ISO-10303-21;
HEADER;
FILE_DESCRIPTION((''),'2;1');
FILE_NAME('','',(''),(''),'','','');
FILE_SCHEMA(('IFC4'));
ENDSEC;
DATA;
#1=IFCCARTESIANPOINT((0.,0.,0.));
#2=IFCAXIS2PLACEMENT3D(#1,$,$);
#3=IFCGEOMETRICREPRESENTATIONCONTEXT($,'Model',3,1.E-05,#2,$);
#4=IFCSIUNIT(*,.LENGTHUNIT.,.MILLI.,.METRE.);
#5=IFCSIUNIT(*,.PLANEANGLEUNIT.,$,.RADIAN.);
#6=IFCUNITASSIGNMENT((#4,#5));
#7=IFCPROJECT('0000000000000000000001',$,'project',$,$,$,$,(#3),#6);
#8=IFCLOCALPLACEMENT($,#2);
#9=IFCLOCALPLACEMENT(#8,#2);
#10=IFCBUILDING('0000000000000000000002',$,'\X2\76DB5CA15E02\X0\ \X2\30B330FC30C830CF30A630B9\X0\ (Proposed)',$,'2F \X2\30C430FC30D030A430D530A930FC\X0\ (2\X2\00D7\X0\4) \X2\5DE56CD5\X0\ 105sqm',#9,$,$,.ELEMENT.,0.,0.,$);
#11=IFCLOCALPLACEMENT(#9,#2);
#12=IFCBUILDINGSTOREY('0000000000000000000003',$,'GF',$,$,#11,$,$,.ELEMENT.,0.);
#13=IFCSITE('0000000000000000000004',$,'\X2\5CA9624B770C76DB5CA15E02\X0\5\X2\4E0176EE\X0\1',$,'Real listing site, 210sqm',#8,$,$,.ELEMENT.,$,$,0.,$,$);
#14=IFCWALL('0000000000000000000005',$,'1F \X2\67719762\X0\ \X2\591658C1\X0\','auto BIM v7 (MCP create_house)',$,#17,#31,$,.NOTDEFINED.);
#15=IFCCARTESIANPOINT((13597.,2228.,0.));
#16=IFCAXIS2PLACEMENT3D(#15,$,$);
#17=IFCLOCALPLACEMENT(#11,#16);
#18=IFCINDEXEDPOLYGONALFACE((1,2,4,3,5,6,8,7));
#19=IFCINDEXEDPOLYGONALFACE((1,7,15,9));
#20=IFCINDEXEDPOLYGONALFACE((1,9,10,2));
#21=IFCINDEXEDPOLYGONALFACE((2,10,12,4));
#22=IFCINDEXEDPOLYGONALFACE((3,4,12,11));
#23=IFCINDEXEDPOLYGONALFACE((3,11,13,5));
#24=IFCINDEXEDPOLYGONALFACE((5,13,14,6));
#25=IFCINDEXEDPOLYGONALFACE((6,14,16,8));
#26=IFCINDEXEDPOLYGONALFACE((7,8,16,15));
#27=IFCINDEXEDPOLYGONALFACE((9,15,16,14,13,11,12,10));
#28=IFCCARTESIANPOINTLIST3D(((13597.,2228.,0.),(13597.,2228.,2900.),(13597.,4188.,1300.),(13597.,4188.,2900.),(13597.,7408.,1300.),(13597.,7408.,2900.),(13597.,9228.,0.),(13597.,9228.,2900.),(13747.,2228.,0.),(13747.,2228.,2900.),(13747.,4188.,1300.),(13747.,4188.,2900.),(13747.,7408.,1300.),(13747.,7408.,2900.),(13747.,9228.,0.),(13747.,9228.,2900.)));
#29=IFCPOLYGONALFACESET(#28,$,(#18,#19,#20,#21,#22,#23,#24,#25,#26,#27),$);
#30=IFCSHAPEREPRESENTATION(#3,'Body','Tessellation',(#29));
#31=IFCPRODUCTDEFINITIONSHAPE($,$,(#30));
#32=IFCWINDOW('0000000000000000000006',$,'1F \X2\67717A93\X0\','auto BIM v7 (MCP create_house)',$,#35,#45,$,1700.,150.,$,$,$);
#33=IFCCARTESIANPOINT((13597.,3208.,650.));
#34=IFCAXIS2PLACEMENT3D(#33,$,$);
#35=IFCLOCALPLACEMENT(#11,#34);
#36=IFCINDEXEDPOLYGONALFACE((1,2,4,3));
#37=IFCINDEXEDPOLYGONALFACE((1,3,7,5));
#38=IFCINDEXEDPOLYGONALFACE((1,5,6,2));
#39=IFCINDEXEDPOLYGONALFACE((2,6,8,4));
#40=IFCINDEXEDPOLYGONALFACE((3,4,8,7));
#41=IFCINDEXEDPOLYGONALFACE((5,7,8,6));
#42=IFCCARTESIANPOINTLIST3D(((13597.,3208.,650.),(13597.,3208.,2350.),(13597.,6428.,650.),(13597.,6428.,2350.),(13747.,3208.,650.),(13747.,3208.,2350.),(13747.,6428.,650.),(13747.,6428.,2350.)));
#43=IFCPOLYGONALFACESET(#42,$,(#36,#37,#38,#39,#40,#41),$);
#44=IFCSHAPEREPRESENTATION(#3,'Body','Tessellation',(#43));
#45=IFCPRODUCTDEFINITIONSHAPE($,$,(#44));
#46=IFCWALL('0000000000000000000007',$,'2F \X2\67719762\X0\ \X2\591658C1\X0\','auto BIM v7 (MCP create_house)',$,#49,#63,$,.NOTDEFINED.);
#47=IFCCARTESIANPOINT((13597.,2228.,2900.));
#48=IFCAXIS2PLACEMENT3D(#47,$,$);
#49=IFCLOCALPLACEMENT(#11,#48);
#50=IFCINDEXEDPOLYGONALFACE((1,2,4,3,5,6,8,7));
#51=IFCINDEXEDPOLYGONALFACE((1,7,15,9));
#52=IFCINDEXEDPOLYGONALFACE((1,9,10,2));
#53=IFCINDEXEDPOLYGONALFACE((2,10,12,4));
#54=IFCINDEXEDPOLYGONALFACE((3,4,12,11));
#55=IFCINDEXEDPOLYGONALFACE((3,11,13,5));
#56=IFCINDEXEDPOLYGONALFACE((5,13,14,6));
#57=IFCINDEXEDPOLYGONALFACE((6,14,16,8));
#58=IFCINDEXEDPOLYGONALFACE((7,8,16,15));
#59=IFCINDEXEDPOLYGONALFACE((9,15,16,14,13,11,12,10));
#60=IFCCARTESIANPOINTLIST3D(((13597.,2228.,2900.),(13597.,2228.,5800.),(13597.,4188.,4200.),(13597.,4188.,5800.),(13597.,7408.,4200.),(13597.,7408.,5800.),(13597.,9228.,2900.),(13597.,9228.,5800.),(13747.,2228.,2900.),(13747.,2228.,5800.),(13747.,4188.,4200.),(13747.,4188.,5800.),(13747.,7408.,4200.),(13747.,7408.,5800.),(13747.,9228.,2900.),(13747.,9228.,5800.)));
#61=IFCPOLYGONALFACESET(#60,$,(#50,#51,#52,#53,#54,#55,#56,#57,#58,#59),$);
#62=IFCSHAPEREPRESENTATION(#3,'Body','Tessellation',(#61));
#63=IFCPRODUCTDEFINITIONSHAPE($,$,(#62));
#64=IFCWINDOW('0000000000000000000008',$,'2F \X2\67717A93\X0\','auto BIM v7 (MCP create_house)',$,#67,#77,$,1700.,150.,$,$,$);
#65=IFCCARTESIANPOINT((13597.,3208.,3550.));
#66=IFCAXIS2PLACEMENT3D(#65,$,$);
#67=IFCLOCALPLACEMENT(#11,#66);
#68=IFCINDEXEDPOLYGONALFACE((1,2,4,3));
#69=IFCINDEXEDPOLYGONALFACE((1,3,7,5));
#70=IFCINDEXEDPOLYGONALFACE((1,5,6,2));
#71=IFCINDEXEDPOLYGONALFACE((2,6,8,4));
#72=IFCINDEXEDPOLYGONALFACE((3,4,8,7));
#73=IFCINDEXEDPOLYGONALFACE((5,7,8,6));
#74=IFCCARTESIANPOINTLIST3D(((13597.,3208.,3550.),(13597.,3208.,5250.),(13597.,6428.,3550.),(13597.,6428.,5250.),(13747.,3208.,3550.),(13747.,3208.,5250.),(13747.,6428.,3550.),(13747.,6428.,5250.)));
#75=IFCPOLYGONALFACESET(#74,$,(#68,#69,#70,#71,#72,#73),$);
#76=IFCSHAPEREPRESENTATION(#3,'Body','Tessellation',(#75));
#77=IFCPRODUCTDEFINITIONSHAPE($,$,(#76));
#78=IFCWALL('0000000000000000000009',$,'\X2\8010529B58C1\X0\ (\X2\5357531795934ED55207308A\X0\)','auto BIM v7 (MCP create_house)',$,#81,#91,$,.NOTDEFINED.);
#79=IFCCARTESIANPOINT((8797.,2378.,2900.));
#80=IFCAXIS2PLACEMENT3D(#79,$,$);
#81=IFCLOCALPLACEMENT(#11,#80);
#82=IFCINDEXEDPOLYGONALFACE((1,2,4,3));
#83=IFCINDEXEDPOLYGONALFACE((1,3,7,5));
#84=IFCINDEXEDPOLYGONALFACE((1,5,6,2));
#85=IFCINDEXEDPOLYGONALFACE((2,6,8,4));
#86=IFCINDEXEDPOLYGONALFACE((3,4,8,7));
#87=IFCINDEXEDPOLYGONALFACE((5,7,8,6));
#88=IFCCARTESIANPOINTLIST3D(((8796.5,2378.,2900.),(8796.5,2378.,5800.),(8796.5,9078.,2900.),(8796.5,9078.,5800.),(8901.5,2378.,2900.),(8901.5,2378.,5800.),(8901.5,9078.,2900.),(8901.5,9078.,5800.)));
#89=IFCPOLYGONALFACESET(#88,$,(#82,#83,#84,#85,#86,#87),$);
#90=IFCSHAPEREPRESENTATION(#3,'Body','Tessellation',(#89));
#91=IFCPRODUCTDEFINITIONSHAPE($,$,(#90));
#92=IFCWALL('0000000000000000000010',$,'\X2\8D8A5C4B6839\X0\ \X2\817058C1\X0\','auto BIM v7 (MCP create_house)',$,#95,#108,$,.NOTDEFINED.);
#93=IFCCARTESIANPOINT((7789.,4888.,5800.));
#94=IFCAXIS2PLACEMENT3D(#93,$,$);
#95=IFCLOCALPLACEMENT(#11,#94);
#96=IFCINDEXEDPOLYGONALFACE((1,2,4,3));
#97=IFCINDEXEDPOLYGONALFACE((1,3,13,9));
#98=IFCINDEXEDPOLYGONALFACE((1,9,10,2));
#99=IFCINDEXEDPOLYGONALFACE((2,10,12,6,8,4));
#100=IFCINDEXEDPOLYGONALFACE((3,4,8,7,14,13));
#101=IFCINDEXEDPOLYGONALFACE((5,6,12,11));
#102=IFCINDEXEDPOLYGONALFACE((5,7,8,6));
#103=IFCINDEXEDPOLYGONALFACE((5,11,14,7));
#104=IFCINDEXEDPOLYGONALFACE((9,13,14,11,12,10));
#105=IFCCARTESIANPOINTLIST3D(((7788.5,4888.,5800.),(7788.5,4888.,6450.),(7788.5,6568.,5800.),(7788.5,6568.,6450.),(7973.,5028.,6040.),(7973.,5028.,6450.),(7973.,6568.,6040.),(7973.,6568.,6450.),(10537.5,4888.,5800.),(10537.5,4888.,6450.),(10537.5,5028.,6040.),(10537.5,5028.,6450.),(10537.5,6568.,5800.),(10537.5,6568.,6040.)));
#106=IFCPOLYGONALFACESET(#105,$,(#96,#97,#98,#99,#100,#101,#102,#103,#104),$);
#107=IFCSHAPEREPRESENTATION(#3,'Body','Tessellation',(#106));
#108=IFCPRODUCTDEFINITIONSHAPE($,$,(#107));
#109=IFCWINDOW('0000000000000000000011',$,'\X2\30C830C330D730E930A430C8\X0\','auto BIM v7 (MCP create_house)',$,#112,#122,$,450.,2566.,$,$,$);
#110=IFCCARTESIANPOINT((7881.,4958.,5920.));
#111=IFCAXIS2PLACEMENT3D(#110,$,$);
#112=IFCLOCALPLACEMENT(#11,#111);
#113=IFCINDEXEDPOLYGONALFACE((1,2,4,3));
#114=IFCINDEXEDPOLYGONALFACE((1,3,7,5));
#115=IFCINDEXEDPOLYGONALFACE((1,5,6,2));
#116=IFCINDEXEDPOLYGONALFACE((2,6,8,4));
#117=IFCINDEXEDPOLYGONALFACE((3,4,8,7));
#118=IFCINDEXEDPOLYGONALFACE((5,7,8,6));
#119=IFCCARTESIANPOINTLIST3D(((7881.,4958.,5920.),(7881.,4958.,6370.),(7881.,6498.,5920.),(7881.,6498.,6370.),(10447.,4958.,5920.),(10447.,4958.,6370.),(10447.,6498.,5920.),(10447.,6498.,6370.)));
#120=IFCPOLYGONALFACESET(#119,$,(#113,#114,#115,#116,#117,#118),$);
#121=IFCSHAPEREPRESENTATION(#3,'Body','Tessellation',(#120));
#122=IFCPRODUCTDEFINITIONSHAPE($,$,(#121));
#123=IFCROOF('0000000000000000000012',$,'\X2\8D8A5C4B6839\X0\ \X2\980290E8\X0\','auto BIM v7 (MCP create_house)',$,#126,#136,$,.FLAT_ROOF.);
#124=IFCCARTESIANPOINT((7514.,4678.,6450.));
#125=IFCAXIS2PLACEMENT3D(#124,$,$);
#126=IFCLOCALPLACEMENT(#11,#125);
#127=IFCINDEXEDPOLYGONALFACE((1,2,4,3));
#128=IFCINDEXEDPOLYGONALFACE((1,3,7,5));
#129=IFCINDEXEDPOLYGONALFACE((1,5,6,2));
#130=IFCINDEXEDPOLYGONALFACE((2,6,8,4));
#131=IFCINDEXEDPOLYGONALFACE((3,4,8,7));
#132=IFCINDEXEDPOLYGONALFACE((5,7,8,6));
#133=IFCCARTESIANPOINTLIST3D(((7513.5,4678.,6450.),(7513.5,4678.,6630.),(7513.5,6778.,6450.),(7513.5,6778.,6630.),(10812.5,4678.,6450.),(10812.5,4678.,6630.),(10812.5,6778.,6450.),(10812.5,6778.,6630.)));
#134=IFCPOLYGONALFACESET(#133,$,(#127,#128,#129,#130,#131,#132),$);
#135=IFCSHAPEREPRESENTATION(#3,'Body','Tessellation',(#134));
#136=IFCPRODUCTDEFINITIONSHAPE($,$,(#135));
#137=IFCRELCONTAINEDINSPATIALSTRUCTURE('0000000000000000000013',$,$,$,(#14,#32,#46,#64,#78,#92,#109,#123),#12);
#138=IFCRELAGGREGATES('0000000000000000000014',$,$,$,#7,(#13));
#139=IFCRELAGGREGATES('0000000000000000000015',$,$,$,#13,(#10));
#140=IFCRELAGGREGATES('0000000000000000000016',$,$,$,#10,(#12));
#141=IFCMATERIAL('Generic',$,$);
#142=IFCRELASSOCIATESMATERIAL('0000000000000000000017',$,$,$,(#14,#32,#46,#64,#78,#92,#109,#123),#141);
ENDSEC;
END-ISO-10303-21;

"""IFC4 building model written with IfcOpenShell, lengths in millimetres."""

from ifc_helpers import new_model, si_unit, frame, frame_2d, origin, place, context, project, spatial, rectangle, extrude, material, element, fill, save


model = new_model("IFC4")

# Units and contexts
model_context = context("Model", 3, precision=1e-05, world=origin())
ifc_project = project(units=[si_unit("LENGTHUNIT", "METRE", prefix="MILLI"), si_unit("PLANEANGLEUNIT", "RADIAN")], contexts=[model_context])

# Site, building, storey
site_placement = place(None, origin())
site = spatial("IfcSite", under=ifc_project, at=site_placement, Name="岩手県盛岡市5丁目1", ObjectType="Real listing site, 210sqm", CompositionType="ELEMENT", RefElevation=0.0)
building_placement = place(site_placement, origin())
building = spatial("IfcBuilding", under=site, at=building_placement, Name="盛岡市 コートハウス (Proposed)", ObjectType="2F ツーバイフォー (2×4) 工法 105sqm", CompositionType="ELEMENT", ElevationOfRefHeight=0.0, ElevationOfTerrain=0.0)
storey_placement = place(building_placement, origin())
storey = spatial("IfcBuildingStorey", under=building, at=storey_placement, Name="GF", CompositionType="ELEMENT", Elevation=0.0)

# Shared definitions
ifc_material = material(Name="Generic")

# Wall, opening, window
wall_1_placement = place(storey_placement, frame((13597.0, 2228.0, 0.0)))
wall_1 = element("IfcWall", 1, at=wall_1_placement, inside=storey, material=ifc_material, Name="1F 東面 外壁", Description="auto BIM v7 (MCP create_house)", PredefinedType="NOTDEFINED", context=model_context, shape_type="SweptSolid", body=[
    extrude(rectangle(XDim=150.0, YDim=7000.0, at=frame_2d((75.0, 3500.0))), frame((13597.0, 2228.0, 0.0)), (0.0, 0.0, 1.0), 2900.0),
])
opening_1_placement = place(storey_placement, frame((13597.0, 3208.0, 650.0)))
opening_1 = element("IfcOpeningElement", 2, at=opening_1_placement, cuts=wall_1, PredefinedType="NOTDEFINED", context=model_context, shape_type="SweptSolid", body=[
    extrude(rectangle(XDim=150.0, YDim=3220.0, at=frame_2d((75.0, 1610.0))), frame((13597.0, 3208.0, 650.0)), (0.0, 0.0, 1.0), 1700.0),
])
window_1_placement = place(storey_placement, frame((13597.0, 3208.0, 650.0)))
window_1 = element("IfcWindow", 3, at=window_1_placement, inside=storey, material=ifc_material, Name="1F 東窓", Description="auto BIM v7 (MCP create_house)", OverallHeight=1700.0, OverallWidth=150.0, context=model_context, shape_type="SweptSolid", body=[
    extrude(rectangle(XDim=150.0, YDim=3220.0, at=frame_2d((75.0, 1610.0))), frame((13597.0, 3208.0, 650.0)), (0.0, 0.0, 1.0), 1700.0),
])
fill(opening_1, window_1)

# Wall, opening, window
wall_2_placement = place(storey_placement, frame((13597.0, 2228.0, 2900.0)))
wall_2 = element("IfcWall", 4, at=wall_2_placement, inside=storey, material=ifc_material, Name="2F 東面 外壁", Description="auto BIM v7 (MCP create_house)", PredefinedType="NOTDEFINED", context=model_context, shape_type="SweptSolid", body=[
    extrude(rectangle(XDim=150.0, YDim=7000.0, at=frame_2d((75.0, 3500.0))), frame((13597.0, 2228.0, 2900.0)), (0.0, 0.0, 1.0), 2900.0),
])
opening_2_placement = place(storey_placement, frame((13597.0, 3208.0, 3550.0)))
opening_2 = element("IfcOpeningElement", 5, at=opening_2_placement, cuts=wall_2, PredefinedType="NOTDEFINED", context=model_context, shape_type="SweptSolid", body=[
    extrude(rectangle(XDim=150.0, YDim=3220.0, at=frame_2d((75.0, 1610.0))), frame((13597.0, 3208.0, 3550.0)), (0.0, 0.0, 1.0), 1700.0),
])
window_2_placement = place(storey_placement, frame((13597.0, 3208.0, 3550.0)))
window_2 = element("IfcWindow", 6, at=window_2_placement, inside=storey, material=ifc_material, Name="2F 東窓", Description="auto BIM v7 (MCP create_house)", OverallHeight=1700.0, OverallWidth=150.0, context=model_context, shape_type="SweptSolid", body=[
    extrude(rectangle(XDim=150.0, YDim=3220.0, at=frame_2d((75.0, 1610.0))), frame((13597.0, 3208.0, 3550.0)), (0.0, 0.0, 1.0), 1700.0),
])
fill(opening_2, window_2)

# Wall
wall_3_placement = place(storey_placement, frame((8797.0, 2378.0, 2900.0)))
element("IfcWall", 7, at=wall_3_placement, inside=storey, material=ifc_material, Name="耐力壁 (南北間仕切り)", Description="auto BIM v7 (MCP create_house)", PredefinedType="NOTDEFINED", context=model_context, shape_type="SweptSolid", body=[
    extrude(rectangle(XDim=105.0, YDim=6700.0, at=frame_2d((52.0, 3350.0))), frame((8797.0, 2378.0, 2900.0)), (0.0, 0.0, 1.0), 2900.0),
])

# Wall, opening, window
wall_4_placement = place(storey_placement, frame((7789.0, 4888.0, 5800.0)))
wall_4 = element("IfcWall", 8, at=wall_4_placement, inside=storey, material=ifc_material, Name="越屋根 腰壁", Description="auto BIM v7 (MCP create_house)", PredefinedType="NOTDEFINED", context=model_context, shape_type="SweptSolid", body=[
    extrude(rectangle(XDim=2749.0, YDim=1680.0, at=frame_2d((1374.0, 840.0))), frame((7789.0, 4888.0, 5800.0)), (0.0, 0.0, 1.0), 650.0),
])
opening_3_placement = place(storey_placement, frame((7881.0, 4958.0, 5920.0)))
opening_3 = element("IfcOpeningElement", 9, at=opening_3_placement, cuts=wall_4, PredefinedType="NOTDEFINED", context=model_context, shape_type="SweptSolid", body=[
    extrude(rectangle(XDim=2566.0, YDim=1540.0, at=frame_2d((1283.0, 770.0))), frame((7881.0, 4958.0, 5920.0)), (0.0, 0.0, 1.0), 450.0),
])
window_3_placement = place(storey_placement, frame((7881.0, 4958.0, 5920.0)))
window_3 = element("IfcWindow", 10, at=window_3_placement, inside=storey, material=ifc_material, Name="トップライト", Description="auto BIM v7 (MCP create_house)", OverallHeight=450.0, OverallWidth=2566.0, context=model_context, shape_type="SweptSolid", body=[
    extrude(rectangle(XDim=2566.0, YDim=1540.0, at=frame_2d((1283.0, 770.0))), frame((7881.0, 4958.0, 5920.0)), (0.0, 0.0, 1.0), 450.0),
])
fill(opening_3, window_3)

# Roof
roof_placement = place(storey_placement, frame((7514.0, 4678.0, 6450.0)))
element("IfcRoof", 11, at=roof_placement, inside=storey, material=ifc_material, Name="越屋根 頂部", Description="auto BIM v7 (MCP create_house)", PredefinedType="FLAT_ROOF", context=model_context, shape_type="SweptSolid", body=[
    extrude(rectangle(XDim=3299.0, YDim=2100.0, at=frame_2d((1649.0, 1050.0))), frame((7514.0, 4678.0, 6450.0)), (0.0, 0.0, 1.0), 180.0),
])

save(model, "model.ifc")
